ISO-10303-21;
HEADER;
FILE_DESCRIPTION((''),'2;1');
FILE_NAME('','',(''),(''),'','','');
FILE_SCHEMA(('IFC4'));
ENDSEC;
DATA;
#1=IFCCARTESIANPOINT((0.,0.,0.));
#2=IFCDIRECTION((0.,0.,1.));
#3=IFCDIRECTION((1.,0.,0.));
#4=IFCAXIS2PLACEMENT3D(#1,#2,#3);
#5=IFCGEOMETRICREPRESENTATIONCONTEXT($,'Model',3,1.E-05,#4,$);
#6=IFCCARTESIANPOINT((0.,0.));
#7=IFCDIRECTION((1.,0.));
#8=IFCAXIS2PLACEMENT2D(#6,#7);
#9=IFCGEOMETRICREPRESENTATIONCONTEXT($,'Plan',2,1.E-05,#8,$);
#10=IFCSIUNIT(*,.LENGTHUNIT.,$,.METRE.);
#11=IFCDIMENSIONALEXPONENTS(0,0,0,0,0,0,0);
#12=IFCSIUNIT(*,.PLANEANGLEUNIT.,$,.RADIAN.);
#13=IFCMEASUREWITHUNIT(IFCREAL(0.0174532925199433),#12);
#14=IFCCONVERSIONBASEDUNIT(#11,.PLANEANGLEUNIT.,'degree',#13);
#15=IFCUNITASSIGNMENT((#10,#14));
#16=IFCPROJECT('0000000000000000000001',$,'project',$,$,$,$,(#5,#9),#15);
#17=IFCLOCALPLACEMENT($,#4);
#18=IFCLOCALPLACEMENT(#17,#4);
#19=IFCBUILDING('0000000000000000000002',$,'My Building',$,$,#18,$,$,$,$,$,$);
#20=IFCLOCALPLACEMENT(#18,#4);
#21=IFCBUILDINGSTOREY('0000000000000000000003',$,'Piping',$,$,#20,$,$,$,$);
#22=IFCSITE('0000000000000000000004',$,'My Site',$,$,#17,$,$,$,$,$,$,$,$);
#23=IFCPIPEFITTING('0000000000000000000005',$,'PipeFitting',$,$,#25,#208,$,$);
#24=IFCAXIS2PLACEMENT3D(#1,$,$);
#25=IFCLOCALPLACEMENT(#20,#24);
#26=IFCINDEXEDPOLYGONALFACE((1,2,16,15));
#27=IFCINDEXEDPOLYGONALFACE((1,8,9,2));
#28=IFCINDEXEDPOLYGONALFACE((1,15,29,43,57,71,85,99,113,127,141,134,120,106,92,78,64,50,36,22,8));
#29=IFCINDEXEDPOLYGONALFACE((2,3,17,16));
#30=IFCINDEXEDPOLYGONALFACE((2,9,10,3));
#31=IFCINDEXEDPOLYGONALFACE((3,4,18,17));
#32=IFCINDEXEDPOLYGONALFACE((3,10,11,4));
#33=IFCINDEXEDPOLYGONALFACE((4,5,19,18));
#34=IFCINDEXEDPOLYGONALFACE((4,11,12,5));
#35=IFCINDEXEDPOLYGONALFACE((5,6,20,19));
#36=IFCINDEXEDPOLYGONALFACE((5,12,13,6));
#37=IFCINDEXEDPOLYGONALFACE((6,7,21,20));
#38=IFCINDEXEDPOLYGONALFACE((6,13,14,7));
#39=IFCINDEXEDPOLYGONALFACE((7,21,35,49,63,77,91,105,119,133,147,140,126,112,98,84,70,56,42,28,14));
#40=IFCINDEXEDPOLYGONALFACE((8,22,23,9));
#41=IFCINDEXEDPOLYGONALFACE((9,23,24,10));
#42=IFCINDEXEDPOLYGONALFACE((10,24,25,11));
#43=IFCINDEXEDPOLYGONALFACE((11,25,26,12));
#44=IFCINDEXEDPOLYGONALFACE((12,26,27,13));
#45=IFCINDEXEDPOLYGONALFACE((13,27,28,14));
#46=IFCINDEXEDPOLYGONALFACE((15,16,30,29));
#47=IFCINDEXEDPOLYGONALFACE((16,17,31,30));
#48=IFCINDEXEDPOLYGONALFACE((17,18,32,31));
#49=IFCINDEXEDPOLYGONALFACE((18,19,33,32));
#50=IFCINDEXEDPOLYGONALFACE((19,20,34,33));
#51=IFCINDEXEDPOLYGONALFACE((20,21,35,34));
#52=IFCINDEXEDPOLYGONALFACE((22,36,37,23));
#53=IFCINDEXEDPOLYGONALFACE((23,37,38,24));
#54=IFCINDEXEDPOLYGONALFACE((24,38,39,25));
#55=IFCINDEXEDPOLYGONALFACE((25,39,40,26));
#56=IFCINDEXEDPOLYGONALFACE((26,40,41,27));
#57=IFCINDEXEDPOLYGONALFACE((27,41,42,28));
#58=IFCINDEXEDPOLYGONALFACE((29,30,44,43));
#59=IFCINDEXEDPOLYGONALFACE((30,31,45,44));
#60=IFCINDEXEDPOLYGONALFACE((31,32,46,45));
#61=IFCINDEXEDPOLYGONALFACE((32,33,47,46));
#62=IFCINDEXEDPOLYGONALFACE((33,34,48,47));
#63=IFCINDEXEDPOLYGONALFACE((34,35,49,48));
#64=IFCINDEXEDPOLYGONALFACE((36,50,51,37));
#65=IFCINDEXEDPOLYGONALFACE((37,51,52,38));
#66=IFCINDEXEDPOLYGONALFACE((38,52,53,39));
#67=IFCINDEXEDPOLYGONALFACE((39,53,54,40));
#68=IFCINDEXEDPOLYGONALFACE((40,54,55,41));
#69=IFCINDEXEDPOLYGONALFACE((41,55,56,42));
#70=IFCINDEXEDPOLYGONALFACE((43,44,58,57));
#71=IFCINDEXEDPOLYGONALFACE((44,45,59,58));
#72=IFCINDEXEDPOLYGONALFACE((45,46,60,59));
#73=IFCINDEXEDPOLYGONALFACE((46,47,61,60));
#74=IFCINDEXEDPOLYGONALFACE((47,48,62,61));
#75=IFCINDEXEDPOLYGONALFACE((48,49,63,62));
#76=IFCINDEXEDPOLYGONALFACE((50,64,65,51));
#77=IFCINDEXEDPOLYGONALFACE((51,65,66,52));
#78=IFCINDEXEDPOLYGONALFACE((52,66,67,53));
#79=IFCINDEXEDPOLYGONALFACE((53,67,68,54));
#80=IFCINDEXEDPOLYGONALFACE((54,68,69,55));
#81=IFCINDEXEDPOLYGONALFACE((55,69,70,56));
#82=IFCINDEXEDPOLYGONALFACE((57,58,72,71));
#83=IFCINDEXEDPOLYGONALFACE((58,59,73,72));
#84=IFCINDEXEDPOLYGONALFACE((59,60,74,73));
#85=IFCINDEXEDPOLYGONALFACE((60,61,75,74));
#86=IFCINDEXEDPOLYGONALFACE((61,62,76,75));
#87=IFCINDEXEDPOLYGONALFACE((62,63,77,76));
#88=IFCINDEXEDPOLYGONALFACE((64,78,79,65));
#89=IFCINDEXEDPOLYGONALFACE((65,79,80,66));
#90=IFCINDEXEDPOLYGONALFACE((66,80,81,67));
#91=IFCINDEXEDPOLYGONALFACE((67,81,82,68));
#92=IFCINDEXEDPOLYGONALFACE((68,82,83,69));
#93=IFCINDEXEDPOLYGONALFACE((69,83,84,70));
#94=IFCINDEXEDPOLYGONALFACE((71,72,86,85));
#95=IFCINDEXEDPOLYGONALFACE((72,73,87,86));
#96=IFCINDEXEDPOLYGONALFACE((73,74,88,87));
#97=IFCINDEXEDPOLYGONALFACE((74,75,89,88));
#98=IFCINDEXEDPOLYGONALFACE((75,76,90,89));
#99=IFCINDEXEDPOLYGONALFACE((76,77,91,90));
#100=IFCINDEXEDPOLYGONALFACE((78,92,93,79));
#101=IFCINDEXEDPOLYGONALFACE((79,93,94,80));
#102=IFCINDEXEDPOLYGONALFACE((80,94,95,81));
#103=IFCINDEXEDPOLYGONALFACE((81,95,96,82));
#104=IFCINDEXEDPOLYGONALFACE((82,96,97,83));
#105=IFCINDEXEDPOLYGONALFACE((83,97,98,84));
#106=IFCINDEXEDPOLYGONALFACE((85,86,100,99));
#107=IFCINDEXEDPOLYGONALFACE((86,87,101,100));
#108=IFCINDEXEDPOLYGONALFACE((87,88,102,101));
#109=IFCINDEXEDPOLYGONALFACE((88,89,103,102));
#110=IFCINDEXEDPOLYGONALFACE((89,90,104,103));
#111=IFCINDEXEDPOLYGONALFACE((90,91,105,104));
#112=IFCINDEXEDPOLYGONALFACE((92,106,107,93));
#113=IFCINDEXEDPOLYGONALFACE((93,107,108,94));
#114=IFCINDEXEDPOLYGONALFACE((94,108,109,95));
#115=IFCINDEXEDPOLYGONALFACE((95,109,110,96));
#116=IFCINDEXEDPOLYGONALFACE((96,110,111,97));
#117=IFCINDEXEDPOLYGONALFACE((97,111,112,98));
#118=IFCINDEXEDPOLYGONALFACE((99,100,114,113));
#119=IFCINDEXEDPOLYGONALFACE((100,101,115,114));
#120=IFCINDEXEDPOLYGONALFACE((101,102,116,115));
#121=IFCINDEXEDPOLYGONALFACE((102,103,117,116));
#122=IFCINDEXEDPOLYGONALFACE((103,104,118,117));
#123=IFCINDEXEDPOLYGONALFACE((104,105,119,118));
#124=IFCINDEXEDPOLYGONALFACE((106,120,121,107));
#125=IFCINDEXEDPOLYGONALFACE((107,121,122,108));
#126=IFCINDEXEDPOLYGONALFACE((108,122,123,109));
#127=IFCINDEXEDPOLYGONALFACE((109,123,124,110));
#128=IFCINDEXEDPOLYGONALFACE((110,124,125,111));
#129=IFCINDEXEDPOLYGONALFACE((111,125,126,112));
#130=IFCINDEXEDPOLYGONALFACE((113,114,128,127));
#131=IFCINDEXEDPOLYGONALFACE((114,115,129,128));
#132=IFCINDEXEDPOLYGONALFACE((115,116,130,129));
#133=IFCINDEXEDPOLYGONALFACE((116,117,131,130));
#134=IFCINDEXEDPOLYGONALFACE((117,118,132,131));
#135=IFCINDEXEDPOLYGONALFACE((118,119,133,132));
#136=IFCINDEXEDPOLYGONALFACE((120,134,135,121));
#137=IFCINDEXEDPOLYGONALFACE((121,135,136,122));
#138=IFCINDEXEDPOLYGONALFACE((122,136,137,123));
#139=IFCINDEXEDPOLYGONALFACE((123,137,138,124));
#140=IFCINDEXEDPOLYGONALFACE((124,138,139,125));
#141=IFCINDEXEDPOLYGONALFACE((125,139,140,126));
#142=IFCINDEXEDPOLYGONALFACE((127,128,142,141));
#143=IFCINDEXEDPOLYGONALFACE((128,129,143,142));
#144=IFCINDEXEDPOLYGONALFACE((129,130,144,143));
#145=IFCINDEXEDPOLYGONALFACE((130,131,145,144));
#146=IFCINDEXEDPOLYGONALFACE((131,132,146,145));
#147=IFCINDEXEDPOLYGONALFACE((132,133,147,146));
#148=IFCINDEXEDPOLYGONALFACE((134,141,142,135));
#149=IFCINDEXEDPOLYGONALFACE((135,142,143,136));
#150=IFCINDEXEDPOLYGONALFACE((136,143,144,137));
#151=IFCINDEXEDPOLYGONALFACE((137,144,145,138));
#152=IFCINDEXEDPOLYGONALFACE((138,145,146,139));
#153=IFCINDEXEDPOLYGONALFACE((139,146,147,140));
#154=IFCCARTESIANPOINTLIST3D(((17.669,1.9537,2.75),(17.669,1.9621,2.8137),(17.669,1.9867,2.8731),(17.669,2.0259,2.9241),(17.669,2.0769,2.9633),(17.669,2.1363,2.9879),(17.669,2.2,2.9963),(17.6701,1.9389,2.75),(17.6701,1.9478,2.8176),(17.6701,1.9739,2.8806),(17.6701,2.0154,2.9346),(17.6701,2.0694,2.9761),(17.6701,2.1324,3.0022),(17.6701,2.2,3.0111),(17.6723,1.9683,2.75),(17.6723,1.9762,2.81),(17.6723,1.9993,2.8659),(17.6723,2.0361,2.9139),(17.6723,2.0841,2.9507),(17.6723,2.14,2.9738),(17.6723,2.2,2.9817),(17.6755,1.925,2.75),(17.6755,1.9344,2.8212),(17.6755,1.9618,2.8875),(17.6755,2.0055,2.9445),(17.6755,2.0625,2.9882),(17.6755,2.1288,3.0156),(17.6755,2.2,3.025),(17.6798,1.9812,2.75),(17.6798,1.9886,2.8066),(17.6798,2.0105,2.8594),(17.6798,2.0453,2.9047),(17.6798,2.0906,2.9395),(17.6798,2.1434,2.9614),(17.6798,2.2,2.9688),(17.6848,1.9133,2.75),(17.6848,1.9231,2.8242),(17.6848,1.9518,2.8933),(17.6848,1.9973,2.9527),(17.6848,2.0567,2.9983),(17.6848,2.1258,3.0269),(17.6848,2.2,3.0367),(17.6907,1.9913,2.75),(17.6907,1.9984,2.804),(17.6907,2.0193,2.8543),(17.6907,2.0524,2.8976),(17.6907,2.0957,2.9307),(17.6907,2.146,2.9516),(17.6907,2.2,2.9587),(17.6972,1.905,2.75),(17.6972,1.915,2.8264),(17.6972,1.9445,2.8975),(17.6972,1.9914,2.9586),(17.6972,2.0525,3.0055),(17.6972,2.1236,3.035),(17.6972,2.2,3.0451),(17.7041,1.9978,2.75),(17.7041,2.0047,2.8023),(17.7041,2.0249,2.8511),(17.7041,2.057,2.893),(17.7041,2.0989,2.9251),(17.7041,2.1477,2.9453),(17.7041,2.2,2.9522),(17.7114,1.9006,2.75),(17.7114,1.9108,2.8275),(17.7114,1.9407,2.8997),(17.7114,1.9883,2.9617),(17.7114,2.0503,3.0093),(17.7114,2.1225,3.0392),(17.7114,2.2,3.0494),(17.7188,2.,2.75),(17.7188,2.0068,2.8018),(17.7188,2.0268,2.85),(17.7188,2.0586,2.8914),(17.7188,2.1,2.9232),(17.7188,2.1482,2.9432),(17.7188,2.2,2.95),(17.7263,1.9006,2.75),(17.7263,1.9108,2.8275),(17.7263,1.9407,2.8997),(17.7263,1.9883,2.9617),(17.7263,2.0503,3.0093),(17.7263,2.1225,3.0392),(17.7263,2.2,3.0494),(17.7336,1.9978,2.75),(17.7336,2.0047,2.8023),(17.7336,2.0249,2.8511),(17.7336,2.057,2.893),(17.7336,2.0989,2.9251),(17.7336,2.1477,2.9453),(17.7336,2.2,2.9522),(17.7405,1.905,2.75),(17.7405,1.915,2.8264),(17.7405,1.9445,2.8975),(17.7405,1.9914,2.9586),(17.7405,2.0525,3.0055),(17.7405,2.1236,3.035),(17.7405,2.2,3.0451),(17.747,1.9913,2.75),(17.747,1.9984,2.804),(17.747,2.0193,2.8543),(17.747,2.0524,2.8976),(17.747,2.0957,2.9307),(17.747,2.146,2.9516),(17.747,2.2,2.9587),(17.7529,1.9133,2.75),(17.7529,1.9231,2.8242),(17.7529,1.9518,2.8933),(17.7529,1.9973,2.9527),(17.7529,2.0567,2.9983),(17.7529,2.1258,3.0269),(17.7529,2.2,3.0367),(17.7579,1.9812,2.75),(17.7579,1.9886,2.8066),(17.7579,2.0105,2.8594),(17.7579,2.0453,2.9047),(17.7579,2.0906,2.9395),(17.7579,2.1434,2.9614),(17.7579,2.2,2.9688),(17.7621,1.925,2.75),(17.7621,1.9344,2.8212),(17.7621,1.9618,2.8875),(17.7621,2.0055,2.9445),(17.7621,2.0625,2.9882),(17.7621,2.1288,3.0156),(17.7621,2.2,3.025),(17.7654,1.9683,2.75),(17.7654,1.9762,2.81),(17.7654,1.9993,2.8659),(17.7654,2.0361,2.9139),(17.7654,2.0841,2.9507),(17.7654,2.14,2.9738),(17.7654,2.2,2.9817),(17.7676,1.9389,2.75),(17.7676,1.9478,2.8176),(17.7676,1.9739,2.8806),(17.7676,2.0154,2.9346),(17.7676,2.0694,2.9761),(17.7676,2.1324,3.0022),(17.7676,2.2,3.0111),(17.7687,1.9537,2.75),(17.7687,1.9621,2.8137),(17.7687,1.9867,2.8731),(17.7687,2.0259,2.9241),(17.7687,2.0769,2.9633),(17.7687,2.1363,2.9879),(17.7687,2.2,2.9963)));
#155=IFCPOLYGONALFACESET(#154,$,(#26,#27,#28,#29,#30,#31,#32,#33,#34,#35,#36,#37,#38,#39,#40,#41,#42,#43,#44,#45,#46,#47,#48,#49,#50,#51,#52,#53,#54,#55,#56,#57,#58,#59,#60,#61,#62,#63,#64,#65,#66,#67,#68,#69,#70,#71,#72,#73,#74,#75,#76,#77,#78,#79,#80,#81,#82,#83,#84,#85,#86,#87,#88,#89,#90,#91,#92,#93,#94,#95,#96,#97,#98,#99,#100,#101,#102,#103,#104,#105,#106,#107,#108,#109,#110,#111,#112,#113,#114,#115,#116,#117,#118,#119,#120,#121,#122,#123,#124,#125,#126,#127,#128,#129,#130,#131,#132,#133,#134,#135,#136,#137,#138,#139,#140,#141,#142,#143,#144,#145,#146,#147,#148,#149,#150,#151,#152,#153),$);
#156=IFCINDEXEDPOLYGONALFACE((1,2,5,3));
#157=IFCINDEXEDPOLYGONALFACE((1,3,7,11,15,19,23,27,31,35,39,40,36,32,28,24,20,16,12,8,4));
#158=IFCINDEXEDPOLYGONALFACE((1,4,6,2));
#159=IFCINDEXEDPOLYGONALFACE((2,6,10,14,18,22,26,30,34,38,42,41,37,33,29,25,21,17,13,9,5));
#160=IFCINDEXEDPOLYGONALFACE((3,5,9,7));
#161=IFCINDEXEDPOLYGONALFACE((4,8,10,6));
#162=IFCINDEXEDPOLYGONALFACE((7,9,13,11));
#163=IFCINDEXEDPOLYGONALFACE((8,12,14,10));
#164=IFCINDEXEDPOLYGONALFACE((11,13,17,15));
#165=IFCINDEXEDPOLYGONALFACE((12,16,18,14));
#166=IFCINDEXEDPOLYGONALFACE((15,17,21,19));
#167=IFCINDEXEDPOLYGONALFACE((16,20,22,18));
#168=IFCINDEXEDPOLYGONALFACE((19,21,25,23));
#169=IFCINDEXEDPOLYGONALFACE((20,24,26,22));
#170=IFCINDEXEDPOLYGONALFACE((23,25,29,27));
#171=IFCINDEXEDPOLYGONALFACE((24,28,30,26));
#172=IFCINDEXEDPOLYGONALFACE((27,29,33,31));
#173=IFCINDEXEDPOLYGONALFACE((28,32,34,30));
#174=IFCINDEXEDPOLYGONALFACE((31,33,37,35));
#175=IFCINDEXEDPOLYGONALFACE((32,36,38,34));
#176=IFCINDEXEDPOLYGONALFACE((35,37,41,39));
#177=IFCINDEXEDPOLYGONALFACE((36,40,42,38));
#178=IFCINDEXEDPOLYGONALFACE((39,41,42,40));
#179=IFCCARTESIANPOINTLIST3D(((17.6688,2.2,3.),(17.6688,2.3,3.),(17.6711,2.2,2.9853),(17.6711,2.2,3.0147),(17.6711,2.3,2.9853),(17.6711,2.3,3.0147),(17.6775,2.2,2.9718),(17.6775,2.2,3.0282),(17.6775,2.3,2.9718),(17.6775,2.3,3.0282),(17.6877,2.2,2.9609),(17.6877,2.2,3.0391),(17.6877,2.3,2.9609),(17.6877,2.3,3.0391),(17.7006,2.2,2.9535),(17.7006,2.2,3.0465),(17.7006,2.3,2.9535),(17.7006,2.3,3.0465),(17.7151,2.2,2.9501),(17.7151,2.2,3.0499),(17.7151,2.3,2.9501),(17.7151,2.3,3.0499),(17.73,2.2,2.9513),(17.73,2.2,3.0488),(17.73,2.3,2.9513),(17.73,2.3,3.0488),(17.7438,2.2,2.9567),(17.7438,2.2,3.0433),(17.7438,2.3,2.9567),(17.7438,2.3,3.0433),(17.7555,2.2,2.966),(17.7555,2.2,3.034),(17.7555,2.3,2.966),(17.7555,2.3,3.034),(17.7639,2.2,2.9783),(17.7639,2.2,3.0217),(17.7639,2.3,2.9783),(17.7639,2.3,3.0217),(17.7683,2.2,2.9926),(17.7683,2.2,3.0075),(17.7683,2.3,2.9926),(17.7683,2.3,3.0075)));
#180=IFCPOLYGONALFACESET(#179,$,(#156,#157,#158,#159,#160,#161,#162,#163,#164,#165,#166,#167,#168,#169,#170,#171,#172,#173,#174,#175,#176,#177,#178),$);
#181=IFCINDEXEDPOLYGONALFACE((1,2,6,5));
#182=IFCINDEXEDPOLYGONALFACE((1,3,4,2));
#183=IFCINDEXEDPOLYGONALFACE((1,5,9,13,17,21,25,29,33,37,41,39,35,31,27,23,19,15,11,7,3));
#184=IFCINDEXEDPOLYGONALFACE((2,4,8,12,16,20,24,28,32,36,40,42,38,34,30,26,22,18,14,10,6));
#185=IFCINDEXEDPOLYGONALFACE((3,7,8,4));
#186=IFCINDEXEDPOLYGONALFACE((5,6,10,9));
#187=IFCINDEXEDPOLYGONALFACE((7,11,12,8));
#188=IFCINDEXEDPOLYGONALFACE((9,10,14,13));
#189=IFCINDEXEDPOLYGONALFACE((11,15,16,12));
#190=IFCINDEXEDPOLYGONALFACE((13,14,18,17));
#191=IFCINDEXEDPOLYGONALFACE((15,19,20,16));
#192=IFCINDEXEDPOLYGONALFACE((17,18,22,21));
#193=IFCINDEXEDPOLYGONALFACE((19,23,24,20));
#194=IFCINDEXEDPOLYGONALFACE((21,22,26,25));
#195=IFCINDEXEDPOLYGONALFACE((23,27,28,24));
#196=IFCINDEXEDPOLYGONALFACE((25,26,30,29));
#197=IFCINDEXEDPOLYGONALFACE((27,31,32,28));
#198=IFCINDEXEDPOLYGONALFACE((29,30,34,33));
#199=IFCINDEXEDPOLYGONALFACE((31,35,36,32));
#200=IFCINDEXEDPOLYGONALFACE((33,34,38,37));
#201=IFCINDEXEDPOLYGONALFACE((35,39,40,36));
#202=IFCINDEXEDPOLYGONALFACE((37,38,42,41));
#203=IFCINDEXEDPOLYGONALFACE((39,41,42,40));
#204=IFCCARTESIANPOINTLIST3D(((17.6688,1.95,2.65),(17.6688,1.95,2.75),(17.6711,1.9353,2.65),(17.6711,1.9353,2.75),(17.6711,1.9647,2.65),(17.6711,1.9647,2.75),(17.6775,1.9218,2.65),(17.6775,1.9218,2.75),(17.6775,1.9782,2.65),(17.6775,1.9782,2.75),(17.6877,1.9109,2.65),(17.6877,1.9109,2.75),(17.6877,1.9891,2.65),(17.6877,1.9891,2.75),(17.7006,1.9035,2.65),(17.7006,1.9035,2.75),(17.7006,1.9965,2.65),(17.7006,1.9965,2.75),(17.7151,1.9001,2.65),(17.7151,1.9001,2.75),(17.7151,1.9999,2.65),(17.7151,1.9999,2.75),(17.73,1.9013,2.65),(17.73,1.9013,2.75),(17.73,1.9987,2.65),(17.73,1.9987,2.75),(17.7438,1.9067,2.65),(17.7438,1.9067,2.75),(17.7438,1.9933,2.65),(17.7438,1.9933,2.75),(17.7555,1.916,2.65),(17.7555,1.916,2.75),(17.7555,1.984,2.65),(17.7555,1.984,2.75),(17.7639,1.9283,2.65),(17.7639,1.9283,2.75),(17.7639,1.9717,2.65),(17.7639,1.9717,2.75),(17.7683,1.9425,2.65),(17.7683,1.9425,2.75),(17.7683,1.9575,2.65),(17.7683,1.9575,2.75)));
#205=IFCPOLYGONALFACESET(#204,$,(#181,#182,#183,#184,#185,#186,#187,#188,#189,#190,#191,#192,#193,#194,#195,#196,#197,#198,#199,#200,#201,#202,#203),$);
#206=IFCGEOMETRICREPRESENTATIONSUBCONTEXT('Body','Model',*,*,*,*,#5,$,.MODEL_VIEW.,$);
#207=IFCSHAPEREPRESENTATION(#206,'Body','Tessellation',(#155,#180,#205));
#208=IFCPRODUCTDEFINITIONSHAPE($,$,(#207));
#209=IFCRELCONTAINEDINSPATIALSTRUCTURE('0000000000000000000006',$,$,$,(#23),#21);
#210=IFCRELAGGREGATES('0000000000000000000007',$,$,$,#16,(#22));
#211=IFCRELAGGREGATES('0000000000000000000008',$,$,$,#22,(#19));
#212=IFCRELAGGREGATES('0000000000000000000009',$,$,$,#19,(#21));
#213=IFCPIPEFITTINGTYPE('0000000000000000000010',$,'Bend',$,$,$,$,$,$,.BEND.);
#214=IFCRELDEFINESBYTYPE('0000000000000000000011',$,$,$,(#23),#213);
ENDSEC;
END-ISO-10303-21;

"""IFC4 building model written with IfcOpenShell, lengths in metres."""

from ifc_helpers import new_model, entity, si_unit, converted_unit, frame, origin_with_axes, origin_2d_with_axis, place, context, subcontext, project, spatial, circle, extrude, source, transform, mapped, type_object, type_shapes, element, save


model = new_model("IFC4")

# Units and contexts
model_context = context("Model", 3, precision=1e-05, world=origin_with_axes())
plan_context = context("Plan", 2, precision=1e-05, world=origin_2d_with_axis())
body_context = subcontext(model_context, "Body", "Model", "MODEL_VIEW")
ifc_project = project(units=[si_unit("LENGTHUNIT", "METRE"), converted_unit("PLANEANGLEUNIT", "degree", entity("IfcReal", 0.0174532925199433), si_unit("PLANEANGLEUNIT", "RADIAN"), dimensions=[0, 0, 0, 0, 0, 0, 0])], contexts=[model_context, plan_context])

# Site, building, storey
site_placement = place(None, origin_with_axes())
site = spatial("IfcSite", under=ifc_project, at=site_placement, Name="My Site")
building_placement = place(site_placement, origin_with_axes())
building = spatial("IfcBuilding", under=site, at=building_placement, Name="My Building")
storey_placement = place(building_placement, origin_with_axes())
storey = spatial("IfcBuildingStorey", under=building, at=storey_placement, Name="Piping")

# Pipe fitting
pipe_fitting_type = type_object("IfcPipeFittingType", Name="Bend", PredefinedType="BEND")
shared_shape = source(origin_with_axes(), body_context, "Body", "SolidModel", [
    entity("IfcSweptDiskSolid", entity("IfcIndexedPolyCurve", entity("IfcCartesianPointList3D", [[0.0, 0.0, -0.1], [0.0, -0.0732, -0.2768], [0.0, -0.25, -0.35]]), [entity("IfcArcIndex", [1, 2, 3])]), 0.05),
    extrude(circle(Radius=0.05), origin_with_axes(), (0.0, 0.0, -1.0), 0.1),
    extrude(circle(Radius=0.05), frame((0.0, -0.25, -0.35), z_axis=(0.0, -1.0, 0.0), x_axis=(1.0, 0.0, 0.0)), (0.0, 0.0, 1.0), 0.1),
])
type_shapes(pipe_fitting_type, [shared_shape])
for number, where, z_axis, x_axis, name in (
    (1, (17.7188, 2.3, 3.0), (0.0, 1.0, 0.0), (-1.0, 0.0, 0.0), "PipeFitting"),
):
    element("IfcPipeFitting", number, at=place(storey_placement, frame(where, z_axis=z_axis, x_axis=x_axis)), inside=storey, type_object=pipe_fitting_type, Name=name, context=body_context, shape_type="MappedRepresentation", body=[
        mapped(shared_shape, transform((0.0, 0.0, 0.0), x_axis=(1.0, 0.0, 0.0), y_axis=(0.0, 1.0, 0.0), z_axis=(0.0, 0.0, 1.0), scale=1.0)),
    ])

save(model, "model.ifc")
